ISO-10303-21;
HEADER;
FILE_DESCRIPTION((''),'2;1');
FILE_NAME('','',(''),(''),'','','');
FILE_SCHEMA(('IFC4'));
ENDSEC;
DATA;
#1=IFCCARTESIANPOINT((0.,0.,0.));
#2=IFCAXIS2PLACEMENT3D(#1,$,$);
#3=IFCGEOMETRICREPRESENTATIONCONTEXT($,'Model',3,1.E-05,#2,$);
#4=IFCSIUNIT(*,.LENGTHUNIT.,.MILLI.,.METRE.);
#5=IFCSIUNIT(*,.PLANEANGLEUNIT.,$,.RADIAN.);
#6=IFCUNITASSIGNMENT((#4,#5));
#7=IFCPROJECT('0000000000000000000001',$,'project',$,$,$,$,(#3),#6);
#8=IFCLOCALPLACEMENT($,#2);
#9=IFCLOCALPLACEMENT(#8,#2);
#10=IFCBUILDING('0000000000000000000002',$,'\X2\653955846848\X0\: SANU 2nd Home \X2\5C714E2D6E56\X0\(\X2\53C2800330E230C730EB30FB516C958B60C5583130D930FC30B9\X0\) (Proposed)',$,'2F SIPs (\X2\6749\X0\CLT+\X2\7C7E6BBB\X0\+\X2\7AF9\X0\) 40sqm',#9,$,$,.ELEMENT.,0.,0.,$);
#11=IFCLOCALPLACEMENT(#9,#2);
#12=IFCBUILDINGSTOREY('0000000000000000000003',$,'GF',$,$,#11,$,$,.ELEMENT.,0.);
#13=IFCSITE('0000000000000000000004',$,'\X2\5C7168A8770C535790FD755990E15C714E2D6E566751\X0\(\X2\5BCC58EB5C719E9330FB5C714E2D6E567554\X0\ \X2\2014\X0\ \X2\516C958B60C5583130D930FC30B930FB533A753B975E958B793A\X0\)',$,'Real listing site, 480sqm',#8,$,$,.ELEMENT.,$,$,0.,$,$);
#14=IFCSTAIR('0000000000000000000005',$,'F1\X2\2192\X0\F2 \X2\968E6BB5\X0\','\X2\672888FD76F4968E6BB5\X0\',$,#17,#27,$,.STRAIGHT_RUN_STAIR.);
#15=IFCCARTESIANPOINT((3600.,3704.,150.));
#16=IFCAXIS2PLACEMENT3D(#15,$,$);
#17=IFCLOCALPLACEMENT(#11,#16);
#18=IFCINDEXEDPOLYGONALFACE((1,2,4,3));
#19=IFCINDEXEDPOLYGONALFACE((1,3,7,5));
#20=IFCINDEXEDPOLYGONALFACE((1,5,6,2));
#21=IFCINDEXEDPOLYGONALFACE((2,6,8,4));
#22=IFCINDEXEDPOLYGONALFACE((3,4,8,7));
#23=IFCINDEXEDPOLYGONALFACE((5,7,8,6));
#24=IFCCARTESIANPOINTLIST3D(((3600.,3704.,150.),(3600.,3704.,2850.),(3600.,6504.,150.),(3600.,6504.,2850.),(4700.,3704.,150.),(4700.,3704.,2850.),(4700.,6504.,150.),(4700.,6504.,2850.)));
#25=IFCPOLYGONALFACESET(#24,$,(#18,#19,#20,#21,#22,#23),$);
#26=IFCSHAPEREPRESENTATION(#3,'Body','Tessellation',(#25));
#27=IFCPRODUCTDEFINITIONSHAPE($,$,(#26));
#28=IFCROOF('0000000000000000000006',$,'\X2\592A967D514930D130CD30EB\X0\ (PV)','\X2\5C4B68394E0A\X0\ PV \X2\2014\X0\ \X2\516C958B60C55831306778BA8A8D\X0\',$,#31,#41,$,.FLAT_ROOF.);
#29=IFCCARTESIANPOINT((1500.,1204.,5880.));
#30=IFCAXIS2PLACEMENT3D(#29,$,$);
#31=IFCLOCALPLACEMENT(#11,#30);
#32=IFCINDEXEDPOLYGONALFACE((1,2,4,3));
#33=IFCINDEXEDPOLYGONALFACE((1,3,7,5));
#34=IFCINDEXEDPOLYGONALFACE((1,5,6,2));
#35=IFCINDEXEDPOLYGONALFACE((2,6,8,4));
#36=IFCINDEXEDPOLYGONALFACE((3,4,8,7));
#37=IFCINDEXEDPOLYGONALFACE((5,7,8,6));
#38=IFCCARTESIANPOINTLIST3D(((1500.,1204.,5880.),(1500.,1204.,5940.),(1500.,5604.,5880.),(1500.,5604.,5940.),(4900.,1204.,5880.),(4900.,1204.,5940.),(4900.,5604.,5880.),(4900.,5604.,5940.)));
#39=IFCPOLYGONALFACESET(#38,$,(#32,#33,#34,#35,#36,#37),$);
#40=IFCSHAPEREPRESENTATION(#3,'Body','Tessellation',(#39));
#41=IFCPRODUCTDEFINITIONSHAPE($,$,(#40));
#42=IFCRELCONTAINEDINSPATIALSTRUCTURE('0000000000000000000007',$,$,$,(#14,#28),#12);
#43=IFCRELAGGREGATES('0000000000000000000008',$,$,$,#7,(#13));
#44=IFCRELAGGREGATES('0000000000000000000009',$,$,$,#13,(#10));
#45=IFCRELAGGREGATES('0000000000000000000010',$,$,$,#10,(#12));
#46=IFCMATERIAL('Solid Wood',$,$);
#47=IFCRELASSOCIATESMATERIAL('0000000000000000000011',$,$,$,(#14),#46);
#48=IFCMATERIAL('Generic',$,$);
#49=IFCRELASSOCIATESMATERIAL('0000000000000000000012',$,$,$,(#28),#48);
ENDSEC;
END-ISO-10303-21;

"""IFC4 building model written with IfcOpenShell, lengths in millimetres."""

from ifc_helpers import new_model, si_unit, frame, frame_2d, origin, place, context, project, spatial, rectangle, extrude, material, element, save


model = new_model("IFC4")

# Units and contexts
model_context = context("Model", 3, precision=1e-05, world=origin())
ifc_project = project(units=[si_unit("LENGTHUNIT", "METRE", prefix="MILLI"), si_unit("PLANEANGLEUNIT", "RADIAN")], contexts=[model_context])

# Site, building, storey
site_placement = place(None, origin())
site = spatial("IfcSite", under=ifc_project, at=site_placement, Name="山梨県南都留郡山中湖村(富士山麓・山中湖畔 — 公開情報ベース・区画非開示)", ObjectType="Real listing site, 480sqm", CompositionType="ELEMENT", RefElevation=0.0)
building_placement = place(site_placement, origin())
building = spatial("IfcBuilding", under=site, at=building_placement, Name="改善案: SANU 2nd Home 山中湖(参考モデル・公開情報ベース) (Proposed)", ObjectType="2F SIPs (杉CLT+籾殻+竹) 40sqm", CompositionType="ELEMENT", ElevationOfRefHeight=0.0, ElevationOfTerrain=0.0)
storey_placement = place(building_placement, origin())
storey = spatial("IfcBuildingStorey", under=building, at=storey_placement, Name="GF", CompositionType="ELEMENT", Elevation=0.0)

# Shared definitions
ifc_material_1 = material(Name="Generic")

# Stair
ifc_material_2 = material(Name="Solid Wood")
stair_placement = place(storey_placement, frame((3600.0, 3704.0, 150.0)))
element("IfcStair", 1, at=stair_placement, inside=storey, material=ifc_material_2, Name="F1→F2 階段", Description="木製直階段", PredefinedType="STRAIGHT_RUN_STAIR", context=model_context, shape_type="SweptSolid", body=[
    extrude(rectangle(XDim=1100.0, YDim=2800.0, at=frame_2d((550.0, 1400.0))), frame((3600.0, 3704.0, 150.0)), (0.0, 0.0, 1.0), 2700.0),
])

# Roof
roof_placement = place(storey_placement, frame((1500.0, 1204.0, 5880.0)))
element("IfcRoof", 2, at=roof_placement, inside=storey, material=ifc_material_1, Name="太陽光パネル (PV)", Description="屋根上 PV — 公開情報で確認", PredefinedType="FLAT_ROOF", context=model_context, shape_type="SweptSolid", body=[
    extrude(rectangle(XDim=3400.0, YDim=4400.0, at=frame_2d((1700.0, 2200.0))), frame((1500.0, 1204.0, 5880.0)), (0.0, 0.0, 1.0), 60.0),
])

save(model, "model.ifc")
